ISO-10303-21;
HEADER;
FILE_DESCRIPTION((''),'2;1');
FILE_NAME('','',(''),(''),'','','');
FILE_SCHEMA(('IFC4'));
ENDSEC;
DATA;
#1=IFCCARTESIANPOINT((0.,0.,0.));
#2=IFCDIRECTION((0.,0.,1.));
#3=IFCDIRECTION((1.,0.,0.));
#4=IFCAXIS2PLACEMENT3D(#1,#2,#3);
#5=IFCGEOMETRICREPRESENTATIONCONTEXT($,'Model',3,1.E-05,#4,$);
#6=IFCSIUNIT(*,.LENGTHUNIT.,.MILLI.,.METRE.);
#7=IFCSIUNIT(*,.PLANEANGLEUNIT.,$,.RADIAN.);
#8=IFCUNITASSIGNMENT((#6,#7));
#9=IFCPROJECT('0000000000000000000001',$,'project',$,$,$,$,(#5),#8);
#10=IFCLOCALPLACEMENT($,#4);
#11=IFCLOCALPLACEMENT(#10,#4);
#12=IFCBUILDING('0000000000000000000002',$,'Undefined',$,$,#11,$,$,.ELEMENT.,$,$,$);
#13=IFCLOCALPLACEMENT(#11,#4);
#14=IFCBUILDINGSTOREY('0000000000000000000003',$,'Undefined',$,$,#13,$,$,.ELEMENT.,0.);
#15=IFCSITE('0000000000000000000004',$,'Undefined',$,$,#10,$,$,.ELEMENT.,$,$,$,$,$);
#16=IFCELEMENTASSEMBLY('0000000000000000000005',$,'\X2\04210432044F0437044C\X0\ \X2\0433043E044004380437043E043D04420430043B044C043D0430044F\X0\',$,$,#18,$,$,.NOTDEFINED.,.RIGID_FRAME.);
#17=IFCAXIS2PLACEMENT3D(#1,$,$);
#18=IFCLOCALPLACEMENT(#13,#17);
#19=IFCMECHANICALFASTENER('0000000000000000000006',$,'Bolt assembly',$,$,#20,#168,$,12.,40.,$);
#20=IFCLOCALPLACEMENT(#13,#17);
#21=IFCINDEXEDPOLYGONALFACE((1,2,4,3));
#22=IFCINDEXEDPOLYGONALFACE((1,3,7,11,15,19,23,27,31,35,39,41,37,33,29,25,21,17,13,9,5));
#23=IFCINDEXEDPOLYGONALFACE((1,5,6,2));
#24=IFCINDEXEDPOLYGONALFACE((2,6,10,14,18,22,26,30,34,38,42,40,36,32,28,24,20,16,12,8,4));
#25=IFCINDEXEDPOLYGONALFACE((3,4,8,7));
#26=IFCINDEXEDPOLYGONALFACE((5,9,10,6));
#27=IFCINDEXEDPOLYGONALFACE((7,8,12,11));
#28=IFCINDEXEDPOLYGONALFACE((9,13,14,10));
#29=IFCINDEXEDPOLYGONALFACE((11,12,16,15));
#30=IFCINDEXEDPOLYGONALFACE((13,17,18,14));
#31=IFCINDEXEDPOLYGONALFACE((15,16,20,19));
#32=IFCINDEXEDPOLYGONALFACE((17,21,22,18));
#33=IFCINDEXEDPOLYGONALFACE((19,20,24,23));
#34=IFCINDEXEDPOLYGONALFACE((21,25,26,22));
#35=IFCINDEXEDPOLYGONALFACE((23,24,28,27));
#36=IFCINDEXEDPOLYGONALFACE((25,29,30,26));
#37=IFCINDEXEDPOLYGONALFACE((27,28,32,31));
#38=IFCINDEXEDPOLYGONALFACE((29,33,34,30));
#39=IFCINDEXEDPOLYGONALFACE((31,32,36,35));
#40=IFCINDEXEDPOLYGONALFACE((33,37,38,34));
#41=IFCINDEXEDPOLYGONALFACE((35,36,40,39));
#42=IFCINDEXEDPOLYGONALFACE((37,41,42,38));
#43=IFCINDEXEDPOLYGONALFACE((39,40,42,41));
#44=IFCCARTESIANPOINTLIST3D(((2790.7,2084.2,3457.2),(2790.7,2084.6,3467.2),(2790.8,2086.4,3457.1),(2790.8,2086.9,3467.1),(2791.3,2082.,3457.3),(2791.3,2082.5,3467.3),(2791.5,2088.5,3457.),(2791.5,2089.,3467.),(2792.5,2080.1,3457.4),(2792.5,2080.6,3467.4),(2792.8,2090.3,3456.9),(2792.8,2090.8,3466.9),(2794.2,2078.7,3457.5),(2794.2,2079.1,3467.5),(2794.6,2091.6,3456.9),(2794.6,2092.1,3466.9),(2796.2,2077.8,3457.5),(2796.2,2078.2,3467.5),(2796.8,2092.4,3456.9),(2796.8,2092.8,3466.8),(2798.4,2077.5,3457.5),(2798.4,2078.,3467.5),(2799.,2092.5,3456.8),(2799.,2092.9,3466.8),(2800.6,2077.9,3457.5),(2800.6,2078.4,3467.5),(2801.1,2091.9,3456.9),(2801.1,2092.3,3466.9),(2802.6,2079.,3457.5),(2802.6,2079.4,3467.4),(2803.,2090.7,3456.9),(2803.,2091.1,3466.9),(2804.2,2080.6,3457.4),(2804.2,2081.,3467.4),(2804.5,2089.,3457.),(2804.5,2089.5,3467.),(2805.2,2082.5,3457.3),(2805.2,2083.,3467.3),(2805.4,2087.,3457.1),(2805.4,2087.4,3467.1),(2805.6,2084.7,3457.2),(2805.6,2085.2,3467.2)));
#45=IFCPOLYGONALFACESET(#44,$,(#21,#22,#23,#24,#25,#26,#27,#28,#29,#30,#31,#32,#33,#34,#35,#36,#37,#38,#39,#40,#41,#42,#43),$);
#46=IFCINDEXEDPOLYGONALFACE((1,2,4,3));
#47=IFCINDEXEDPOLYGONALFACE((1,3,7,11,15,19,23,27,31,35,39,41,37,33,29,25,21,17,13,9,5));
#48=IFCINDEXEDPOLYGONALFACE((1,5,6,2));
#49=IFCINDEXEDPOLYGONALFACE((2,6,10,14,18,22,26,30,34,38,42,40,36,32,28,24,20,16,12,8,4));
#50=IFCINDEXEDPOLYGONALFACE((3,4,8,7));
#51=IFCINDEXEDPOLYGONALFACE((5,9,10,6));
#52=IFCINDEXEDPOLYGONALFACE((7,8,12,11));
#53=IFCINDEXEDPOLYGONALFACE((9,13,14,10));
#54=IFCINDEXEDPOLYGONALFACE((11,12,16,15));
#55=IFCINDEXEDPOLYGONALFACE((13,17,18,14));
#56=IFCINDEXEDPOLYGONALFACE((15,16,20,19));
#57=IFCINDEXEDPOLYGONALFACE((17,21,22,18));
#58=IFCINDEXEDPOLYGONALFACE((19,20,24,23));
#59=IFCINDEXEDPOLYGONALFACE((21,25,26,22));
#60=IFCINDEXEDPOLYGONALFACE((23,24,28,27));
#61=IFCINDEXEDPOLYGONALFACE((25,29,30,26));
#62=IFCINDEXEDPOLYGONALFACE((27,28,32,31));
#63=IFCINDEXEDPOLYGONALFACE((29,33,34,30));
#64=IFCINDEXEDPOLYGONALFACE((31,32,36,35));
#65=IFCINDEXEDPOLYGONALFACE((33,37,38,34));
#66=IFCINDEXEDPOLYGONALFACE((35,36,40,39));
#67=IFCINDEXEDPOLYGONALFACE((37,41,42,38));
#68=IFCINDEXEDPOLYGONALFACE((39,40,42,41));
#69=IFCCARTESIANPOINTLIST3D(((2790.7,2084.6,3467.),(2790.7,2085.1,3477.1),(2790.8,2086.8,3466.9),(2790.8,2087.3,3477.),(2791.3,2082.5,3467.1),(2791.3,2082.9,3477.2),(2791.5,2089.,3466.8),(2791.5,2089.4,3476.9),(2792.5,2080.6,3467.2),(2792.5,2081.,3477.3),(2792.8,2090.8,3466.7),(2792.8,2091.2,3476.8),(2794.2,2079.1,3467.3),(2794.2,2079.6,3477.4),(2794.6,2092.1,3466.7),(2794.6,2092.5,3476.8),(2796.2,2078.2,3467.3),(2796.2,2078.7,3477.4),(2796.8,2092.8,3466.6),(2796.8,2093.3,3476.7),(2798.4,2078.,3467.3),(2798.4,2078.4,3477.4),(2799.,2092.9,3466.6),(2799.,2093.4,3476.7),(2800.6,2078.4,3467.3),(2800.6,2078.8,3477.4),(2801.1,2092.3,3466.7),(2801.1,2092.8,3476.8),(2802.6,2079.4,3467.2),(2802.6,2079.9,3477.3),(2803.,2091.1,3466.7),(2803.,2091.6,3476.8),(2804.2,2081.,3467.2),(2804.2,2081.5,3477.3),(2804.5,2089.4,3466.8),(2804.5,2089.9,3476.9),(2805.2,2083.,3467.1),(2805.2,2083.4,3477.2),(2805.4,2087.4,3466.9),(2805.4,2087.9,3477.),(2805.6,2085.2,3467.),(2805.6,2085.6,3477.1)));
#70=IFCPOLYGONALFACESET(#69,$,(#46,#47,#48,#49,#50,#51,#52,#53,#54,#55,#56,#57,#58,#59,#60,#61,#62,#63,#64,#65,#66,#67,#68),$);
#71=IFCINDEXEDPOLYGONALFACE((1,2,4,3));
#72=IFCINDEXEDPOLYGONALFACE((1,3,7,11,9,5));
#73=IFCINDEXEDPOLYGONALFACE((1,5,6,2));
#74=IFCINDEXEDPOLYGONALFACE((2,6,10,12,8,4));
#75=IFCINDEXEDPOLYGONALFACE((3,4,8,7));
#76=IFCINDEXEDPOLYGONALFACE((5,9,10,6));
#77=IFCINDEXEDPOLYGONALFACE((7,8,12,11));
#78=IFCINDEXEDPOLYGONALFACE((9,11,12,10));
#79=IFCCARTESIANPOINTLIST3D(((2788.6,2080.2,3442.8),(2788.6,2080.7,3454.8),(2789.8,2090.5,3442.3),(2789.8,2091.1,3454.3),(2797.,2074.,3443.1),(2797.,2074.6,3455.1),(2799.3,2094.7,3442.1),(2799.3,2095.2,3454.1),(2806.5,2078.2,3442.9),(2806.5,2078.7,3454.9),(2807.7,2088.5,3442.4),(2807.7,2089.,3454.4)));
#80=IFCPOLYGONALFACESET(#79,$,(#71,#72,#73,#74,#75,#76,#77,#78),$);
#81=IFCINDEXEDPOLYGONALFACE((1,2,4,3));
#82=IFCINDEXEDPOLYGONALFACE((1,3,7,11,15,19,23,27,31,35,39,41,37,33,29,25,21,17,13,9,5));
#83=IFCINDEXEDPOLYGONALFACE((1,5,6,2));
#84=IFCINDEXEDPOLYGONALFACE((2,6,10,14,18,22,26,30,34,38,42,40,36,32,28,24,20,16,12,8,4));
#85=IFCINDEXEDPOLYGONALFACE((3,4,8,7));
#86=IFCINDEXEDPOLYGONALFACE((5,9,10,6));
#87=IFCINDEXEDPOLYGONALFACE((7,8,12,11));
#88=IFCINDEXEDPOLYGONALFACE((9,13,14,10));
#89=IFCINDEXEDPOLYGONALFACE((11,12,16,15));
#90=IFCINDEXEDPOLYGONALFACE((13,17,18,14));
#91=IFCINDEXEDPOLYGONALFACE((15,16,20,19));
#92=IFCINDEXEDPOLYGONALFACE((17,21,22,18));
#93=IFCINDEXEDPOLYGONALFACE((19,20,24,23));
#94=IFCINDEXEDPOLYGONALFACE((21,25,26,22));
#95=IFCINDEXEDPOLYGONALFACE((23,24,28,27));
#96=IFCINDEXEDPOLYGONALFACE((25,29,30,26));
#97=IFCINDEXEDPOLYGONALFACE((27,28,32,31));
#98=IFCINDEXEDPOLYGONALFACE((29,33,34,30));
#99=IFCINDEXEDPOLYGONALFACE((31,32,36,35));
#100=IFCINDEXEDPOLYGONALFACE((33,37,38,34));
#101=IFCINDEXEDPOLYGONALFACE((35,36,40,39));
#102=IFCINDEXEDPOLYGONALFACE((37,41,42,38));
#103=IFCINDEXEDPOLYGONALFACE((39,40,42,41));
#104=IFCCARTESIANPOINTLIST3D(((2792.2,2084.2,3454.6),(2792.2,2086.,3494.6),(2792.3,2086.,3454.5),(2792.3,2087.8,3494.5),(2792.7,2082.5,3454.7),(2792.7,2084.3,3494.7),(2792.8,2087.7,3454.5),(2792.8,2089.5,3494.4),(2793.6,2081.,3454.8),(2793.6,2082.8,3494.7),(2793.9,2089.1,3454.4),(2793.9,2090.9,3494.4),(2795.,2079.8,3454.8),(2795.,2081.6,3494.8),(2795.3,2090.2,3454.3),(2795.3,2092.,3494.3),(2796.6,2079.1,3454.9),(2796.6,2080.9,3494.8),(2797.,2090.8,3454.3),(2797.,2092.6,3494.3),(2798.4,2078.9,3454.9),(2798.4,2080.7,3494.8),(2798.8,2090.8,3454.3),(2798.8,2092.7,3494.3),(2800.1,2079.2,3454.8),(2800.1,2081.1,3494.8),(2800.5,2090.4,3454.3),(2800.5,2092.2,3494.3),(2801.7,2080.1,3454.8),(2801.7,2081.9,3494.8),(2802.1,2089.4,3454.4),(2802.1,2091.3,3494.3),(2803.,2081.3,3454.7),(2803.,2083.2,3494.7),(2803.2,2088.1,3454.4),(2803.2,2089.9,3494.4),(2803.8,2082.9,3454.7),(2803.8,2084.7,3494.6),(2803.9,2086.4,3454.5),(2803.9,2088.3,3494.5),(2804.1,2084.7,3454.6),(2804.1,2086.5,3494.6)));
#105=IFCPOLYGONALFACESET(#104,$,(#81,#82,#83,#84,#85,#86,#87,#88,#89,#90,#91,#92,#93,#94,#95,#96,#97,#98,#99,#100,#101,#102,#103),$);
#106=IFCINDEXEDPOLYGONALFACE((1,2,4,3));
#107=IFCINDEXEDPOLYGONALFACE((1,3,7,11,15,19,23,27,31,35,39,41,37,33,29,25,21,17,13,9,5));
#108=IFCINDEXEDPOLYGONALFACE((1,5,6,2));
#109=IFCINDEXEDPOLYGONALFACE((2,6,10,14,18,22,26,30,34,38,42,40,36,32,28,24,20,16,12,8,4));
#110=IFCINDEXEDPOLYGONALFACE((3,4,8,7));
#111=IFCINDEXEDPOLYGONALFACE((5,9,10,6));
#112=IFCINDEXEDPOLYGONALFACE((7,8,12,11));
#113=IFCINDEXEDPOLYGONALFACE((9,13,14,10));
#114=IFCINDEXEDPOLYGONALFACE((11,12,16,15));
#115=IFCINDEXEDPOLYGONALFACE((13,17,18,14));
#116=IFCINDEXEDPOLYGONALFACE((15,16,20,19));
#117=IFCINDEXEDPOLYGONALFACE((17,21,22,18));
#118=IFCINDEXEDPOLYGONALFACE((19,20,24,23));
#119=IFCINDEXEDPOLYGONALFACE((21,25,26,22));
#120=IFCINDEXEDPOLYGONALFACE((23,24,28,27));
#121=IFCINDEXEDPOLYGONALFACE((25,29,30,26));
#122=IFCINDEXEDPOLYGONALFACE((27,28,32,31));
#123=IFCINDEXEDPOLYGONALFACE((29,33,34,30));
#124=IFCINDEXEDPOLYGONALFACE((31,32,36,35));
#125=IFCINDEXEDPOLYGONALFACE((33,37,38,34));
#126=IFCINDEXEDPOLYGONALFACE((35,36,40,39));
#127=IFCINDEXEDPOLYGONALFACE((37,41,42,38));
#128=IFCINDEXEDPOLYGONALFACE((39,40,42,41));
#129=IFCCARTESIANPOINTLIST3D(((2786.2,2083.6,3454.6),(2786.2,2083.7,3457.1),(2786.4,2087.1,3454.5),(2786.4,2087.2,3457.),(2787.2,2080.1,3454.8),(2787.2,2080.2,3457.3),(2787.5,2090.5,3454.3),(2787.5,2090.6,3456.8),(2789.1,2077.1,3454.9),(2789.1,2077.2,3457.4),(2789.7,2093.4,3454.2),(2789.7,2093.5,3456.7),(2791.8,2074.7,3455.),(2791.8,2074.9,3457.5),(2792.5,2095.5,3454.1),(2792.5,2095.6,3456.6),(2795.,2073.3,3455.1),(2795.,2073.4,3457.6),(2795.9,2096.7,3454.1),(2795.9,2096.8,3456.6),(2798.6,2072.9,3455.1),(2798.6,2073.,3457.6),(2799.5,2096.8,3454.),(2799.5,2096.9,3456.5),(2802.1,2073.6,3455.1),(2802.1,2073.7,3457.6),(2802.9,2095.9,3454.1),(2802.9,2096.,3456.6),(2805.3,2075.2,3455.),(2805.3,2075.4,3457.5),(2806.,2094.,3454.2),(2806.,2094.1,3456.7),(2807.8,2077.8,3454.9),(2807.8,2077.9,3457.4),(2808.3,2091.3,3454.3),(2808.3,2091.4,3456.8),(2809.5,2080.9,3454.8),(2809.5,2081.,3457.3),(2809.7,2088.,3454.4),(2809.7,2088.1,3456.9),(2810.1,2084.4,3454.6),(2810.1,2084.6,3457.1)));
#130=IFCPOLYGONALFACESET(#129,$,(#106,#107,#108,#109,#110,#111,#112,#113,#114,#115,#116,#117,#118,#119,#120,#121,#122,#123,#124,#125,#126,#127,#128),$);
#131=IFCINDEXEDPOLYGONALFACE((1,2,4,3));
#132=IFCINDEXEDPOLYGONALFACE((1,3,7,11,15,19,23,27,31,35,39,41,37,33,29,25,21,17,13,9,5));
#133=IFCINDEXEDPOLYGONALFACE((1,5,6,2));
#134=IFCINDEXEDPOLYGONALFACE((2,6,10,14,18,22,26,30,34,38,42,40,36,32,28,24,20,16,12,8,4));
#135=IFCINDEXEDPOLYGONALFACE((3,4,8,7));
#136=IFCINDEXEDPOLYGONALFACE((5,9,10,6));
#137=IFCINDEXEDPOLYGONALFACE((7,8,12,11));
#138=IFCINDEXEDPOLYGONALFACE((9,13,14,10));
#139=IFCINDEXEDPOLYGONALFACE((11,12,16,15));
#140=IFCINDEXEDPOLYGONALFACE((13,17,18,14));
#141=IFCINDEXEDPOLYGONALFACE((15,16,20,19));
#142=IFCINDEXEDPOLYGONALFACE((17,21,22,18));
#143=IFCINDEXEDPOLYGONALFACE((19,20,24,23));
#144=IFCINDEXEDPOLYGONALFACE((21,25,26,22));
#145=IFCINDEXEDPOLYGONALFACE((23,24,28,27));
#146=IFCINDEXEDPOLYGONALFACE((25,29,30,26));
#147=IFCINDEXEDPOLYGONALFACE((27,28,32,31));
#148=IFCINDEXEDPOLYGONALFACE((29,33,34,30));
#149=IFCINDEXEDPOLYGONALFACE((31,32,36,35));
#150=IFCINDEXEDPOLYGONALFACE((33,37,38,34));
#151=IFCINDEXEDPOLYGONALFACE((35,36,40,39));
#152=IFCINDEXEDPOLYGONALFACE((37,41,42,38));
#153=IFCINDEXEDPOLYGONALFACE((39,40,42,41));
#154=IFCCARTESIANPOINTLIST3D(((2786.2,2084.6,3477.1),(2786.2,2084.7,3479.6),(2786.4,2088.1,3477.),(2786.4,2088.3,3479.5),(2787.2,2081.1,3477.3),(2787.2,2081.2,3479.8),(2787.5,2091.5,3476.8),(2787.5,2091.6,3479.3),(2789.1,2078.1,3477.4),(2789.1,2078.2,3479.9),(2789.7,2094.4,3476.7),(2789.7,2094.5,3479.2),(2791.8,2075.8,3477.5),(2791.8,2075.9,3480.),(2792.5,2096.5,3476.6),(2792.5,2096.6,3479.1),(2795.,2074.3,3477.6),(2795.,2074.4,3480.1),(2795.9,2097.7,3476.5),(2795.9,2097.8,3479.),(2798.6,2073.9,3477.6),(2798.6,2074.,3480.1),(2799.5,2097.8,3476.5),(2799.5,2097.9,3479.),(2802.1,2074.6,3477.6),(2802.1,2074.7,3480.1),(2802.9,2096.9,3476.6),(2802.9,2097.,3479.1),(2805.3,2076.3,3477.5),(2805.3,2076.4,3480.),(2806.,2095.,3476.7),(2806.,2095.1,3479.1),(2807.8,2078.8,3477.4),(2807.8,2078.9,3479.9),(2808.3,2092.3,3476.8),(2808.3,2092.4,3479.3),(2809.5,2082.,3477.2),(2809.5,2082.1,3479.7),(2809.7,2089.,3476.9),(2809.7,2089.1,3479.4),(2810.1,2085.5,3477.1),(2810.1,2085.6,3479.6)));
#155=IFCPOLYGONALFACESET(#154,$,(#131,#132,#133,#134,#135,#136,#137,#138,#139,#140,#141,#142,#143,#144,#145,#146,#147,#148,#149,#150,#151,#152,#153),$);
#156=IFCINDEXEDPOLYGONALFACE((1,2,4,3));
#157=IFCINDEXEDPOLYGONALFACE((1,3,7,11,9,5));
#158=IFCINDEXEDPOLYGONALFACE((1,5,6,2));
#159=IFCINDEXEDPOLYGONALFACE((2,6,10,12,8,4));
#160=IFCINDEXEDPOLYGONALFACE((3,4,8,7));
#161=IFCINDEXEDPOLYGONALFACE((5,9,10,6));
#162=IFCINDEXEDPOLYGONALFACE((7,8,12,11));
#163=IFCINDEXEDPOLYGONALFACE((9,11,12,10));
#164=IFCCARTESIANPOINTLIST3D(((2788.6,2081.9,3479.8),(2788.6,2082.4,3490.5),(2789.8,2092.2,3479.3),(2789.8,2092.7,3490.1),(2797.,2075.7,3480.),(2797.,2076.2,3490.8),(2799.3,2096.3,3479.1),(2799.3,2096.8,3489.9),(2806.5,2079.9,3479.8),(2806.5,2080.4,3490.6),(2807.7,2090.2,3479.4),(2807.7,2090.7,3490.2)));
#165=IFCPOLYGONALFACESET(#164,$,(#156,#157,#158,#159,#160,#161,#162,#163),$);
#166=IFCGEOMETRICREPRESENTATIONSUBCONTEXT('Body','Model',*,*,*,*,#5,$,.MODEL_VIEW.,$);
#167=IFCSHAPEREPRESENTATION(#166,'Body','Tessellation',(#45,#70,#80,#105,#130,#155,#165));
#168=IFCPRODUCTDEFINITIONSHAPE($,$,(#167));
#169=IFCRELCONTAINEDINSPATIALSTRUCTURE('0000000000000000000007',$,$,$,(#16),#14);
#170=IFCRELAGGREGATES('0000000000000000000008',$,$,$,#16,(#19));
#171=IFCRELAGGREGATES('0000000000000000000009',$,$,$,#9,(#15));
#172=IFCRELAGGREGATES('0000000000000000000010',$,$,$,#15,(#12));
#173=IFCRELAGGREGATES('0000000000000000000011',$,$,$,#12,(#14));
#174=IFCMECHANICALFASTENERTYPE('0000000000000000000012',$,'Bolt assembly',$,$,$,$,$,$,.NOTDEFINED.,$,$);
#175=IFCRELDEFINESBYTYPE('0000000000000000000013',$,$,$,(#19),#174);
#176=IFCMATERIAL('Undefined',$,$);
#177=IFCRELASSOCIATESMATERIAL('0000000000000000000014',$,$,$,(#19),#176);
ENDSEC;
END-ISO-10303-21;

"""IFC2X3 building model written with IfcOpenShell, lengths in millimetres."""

from ifc_helpers import new_model, si_unit, frame, origin_with_axes, origin_2d_with_axis, place, context, subcontext, project, spatial, polyline, circle, outline, extrude, source, transform, mapped, material, type_object, element, aggregate, save


model = new_model("IFC2X3")

# Units and contexts
model_context = context("Model", 3, precision=1e-05, world=origin_with_axes())
body_context = subcontext(model_context, "Body", "Model", "MODEL_VIEW")
ifc_project = project(units=[si_unit("LENGTHUNIT", "METRE", prefix="MILLI"), si_unit("PLANEANGLEUNIT", "RADIAN")], contexts=[model_context])

# Site, building, storey
site_placement = place(None, origin_with_axes())
site = spatial("IfcSite", under=ifc_project, at=site_placement, Name="Undefined", CompositionType="ELEMENT")
building_placement = place(site_placement, origin_with_axes())
building = spatial("IfcBuilding", under=site, at=building_placement, Name="Undefined", CompositionType="ELEMENT")
storey_placement = place(building_placement, origin_with_axes())
storey = spatial("IfcBuildingStorey", under=building, at=storey_placement, Name="Undefined", CompositionType="ELEMENT", Elevation=0.0)

# Element assembly
assembly_1_placement = place(storey_placement, origin_with_axes())
assembly_1 = element("IfcElementAssembly", 1, at=assembly_1_placement, inside=storey, Name="Связь горизонтальная", AssemblyPlace="NOTDEFINED", PredefinedType="RIGID_FRAME")

# Mechanical fastener
ifc_material_1 = material(Name="Undefined")
mechanical_fastener_type = type_object("IfcMechanicalFastenerType", Name="Bolt assembly")
shared_shape_1 = source(origin_with_axes(), body_context, "Body", "SweptSolid", [
    extrude(circle(Radius=7.5, at=origin_2d_with_axis()), frame((0.0, 0.1, 0.0), z_axis=(0.0, 1.0, 0.0), x_axis=(1.0, 0.0, 0.0)), (0.0, 0.0, 1.0), 10.0),
    extrude(circle(Radius=7.5, at=origin_2d_with_axis()), frame((0.0, 9.9, 0.0), z_axis=(0.0, 1.0, 0.0), x_axis=(1.0, 0.0, 0.0)), (0.0, 0.0, 1.0), 10.1),
    extrude(outline(polyline([(10.4, 0.0), (5.2, 9.0), (-5.2, 9.0), (-10.4, 0.0), (-5.2, -9.0), (5.2, -9.0), (10.4, 0.0)])), frame((0.0, -14.5, 0.0), z_axis=(0.0, 1.0, 0.0), x_axis=(1.0, 0.0, 0.0)), (0.0, 0.0, 1.0), 12.0),
    extrude(circle(Radius=6.0, at=origin_2d_with_axis()), frame((0.0, -2.5, 0.0), z_axis=(0.0, 1.0, 0.0), x_axis=(1.0, 0.0, 0.0)), (0.0, 0.0, 1.0), 40.0),
    extrude(circle(Radius=12.0, at=origin_2d_with_axis()), frame((0.0, -2.5, 0.0), z_axis=(0.0, 1.0, 0.0), x_axis=(1.0, 0.0, 0.0)), (0.0, 0.0, 1.0), 2.5),
    extrude(circle(Radius=12.0, at=origin_2d_with_axis()), frame((0.0, 20.0, 0.0), z_axis=(0.0, 1.0, 0.0), x_axis=(1.0, 0.0, 0.0)), (0.0, 0.0, 1.0), 2.5),
    extrude(outline(polyline([(10.4, 0.0), (5.2, 9.0), (-5.2, 9.0), (-10.4, 0.0), (-5.2, -9.0), (5.2, -9.0), (10.4, 0.0)])), frame((0.0, 22.5, 0.0), z_axis=(0.0, 1.0, 0.0), x_axis=(1.0, 0.0, 0.0)), (0.0, 0.0, 1.0), 10.8),
])
mechanical_fastener_1_placement = place(assembly_1_placement, frame((2798.1, 2085.0, 3457.1), z_axis=(-0.593795, -0.803786, 0.036536), x_axis=(0.804616, -0.593183, 0.026963)))
mechanical_fastener_1 = element("IfcMechanicalFastener", 2, at=mechanical_fastener_1_placement, type_object=mechanical_fastener_type, material=ifc_material_1, Name="Bolt assembly", NominalDiameter=12.0, NominalLength=40.0, context=body_context, shape_type="MappedRepresentation", body=[
    mapped(shared_shape_1, transform((0.0, 0.0, 0.0))),
])
aggregate(assembly_1, [mechanical_fastener_1])

save(model, "model.ifc")
